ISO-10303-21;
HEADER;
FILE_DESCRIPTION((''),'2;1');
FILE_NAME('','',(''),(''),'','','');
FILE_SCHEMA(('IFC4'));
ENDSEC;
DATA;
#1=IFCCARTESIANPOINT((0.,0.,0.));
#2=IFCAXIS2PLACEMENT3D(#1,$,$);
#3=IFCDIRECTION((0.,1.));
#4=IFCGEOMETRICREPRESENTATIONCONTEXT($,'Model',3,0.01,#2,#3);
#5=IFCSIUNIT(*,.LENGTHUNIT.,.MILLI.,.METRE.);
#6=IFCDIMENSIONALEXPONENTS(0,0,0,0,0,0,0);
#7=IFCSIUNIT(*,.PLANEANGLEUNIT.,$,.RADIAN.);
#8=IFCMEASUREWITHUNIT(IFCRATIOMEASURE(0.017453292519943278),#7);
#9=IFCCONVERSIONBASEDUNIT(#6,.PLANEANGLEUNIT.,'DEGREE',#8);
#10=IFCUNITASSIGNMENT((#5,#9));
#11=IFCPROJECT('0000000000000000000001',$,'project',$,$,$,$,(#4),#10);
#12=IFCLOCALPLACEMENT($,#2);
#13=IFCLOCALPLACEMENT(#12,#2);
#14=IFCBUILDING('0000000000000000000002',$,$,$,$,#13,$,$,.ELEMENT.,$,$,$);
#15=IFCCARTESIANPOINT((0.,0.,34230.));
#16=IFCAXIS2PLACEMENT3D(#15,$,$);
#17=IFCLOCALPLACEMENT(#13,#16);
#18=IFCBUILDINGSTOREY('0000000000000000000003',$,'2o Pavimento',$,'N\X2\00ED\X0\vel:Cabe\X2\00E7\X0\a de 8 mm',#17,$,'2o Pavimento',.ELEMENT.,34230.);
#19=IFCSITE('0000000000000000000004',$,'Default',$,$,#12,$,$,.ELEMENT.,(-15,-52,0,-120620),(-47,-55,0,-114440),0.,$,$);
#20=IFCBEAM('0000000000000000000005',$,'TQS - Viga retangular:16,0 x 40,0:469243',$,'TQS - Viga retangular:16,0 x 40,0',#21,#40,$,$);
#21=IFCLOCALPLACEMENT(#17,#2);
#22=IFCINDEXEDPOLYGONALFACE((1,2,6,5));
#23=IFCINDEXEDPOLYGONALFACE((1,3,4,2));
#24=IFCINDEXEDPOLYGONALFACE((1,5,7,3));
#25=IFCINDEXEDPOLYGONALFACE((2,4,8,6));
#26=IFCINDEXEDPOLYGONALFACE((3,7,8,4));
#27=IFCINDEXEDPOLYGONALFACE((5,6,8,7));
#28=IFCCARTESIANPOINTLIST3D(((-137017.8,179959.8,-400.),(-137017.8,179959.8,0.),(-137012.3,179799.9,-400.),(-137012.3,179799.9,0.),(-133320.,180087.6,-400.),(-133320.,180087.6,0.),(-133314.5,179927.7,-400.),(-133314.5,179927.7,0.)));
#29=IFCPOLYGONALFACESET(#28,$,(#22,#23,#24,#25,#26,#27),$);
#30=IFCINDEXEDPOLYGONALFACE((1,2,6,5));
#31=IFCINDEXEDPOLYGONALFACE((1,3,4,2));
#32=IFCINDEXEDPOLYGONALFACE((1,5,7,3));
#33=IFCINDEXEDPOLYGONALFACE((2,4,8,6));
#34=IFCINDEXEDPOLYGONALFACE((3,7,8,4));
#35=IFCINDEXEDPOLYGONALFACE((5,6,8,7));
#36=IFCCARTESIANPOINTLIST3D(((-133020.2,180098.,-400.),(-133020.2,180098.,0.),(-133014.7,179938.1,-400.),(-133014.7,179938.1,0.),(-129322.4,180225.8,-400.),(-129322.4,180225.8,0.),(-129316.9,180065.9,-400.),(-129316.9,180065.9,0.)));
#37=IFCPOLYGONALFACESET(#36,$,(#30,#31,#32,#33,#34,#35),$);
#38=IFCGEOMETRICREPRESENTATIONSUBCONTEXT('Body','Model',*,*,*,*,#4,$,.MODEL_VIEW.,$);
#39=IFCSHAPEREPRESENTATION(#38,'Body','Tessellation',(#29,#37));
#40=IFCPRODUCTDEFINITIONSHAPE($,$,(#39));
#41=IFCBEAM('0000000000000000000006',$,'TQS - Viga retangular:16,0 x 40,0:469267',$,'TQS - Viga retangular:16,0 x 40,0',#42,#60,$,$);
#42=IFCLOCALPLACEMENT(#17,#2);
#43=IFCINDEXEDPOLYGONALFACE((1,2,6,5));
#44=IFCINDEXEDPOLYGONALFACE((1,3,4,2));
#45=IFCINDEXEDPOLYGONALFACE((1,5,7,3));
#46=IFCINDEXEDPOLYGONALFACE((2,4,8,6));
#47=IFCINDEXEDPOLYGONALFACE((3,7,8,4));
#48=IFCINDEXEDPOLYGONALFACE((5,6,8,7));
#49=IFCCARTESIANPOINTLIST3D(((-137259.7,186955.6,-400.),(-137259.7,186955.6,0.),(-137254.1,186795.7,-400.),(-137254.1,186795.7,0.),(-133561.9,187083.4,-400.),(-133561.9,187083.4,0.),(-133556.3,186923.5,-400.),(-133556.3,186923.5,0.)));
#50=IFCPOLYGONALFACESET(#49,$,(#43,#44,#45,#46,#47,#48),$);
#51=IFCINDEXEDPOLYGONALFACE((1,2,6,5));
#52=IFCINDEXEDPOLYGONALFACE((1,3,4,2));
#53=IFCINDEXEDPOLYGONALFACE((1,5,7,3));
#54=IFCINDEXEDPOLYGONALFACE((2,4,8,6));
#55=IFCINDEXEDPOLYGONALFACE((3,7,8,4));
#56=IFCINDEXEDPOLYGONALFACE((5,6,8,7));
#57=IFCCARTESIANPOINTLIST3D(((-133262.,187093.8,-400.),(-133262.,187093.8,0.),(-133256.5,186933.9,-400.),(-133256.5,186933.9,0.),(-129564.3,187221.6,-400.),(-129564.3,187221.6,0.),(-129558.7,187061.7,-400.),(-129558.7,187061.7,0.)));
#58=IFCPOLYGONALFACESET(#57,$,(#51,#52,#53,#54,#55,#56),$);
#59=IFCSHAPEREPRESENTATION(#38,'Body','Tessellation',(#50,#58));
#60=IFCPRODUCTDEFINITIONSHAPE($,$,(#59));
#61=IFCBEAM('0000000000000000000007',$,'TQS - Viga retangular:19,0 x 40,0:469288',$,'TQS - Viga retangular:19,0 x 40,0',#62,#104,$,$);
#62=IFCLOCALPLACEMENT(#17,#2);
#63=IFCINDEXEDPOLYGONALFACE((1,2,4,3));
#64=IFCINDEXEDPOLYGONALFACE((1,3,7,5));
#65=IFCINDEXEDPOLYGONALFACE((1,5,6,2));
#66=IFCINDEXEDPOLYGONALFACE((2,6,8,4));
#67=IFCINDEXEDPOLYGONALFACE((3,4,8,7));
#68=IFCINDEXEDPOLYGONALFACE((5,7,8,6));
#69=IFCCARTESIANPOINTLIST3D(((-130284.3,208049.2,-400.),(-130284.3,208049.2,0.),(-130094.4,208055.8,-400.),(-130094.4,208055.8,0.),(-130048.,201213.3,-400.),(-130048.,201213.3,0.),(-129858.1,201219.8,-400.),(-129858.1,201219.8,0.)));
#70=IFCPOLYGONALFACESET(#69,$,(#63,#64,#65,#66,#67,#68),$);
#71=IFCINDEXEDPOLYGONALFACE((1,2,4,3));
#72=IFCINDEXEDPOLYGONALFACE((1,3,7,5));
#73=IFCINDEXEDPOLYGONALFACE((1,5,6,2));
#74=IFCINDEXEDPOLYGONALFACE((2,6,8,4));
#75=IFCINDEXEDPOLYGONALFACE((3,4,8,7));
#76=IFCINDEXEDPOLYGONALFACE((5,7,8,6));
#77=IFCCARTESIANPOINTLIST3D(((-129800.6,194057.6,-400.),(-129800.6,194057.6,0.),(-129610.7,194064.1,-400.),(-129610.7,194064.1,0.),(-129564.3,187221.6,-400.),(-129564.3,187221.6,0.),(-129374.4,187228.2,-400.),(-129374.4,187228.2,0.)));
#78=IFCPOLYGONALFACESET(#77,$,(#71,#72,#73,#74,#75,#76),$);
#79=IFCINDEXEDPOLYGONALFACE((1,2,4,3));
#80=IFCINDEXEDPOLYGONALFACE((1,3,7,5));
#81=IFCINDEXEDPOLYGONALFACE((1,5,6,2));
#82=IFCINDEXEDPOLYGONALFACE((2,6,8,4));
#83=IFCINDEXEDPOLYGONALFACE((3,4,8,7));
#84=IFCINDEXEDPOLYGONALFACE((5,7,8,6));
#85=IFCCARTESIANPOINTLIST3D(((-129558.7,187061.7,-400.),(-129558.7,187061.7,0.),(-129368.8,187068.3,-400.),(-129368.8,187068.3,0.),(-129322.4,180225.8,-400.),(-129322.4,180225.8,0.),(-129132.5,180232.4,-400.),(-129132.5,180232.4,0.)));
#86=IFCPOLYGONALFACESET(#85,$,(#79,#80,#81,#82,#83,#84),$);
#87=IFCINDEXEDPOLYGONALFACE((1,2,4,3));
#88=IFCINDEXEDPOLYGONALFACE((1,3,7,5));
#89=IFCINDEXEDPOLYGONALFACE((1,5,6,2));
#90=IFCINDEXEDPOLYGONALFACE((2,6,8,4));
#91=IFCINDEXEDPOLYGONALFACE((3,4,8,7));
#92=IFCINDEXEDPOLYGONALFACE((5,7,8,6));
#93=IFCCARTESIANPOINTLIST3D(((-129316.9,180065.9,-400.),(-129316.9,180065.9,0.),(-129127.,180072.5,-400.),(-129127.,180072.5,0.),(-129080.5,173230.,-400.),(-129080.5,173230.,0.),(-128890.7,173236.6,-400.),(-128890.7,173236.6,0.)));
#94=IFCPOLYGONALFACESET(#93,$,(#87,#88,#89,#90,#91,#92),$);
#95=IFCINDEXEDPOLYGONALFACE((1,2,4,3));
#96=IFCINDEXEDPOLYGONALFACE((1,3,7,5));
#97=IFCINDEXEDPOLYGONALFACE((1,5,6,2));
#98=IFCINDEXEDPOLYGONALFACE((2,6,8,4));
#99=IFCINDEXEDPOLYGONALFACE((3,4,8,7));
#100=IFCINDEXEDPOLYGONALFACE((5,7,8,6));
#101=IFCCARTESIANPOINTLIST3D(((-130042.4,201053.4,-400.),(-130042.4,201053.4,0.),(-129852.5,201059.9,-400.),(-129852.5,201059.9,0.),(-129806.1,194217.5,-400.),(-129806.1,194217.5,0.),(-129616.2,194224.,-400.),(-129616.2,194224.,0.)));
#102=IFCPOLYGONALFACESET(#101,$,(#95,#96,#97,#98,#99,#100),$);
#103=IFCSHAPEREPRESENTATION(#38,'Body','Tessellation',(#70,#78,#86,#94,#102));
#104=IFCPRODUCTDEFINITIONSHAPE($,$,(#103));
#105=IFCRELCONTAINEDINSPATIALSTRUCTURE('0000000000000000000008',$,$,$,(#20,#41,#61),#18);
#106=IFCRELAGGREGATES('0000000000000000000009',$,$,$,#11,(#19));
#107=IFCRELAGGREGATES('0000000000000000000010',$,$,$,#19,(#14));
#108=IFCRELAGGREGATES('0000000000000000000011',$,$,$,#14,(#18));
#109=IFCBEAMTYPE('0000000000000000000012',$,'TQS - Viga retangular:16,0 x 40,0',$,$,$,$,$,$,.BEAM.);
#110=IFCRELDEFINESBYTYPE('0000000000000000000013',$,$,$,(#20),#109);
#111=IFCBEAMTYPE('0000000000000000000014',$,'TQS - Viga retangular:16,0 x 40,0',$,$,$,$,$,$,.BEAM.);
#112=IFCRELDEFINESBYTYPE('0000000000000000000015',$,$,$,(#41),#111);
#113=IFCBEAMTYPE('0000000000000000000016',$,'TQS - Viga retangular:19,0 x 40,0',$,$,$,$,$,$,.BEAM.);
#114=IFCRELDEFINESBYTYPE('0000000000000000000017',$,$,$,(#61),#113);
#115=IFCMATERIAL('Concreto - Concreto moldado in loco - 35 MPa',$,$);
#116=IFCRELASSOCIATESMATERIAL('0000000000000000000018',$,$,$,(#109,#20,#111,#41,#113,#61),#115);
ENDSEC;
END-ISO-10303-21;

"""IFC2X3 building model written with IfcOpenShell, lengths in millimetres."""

from ifc_helpers import new_model, entity, si_unit, converted_unit, direction, frame, frame_2d, origin, place, context, subcontext, project, spatial, rectangle, extrude, source, transform, mapped, material, type_object, type_shapes, element, save


model = new_model("IFC2X3")

# Units and contexts
model_context = context("Model", 3, precision=0.01, world=origin(), true_north=direction((0.0, 1.0)))
body_context = subcontext(model_context, "Body", "Model", "MODEL_VIEW")
ifc_project = project(units=[si_unit("LENGTHUNIT", "METRE", prefix="MILLI"), converted_unit("PLANEANGLEUNIT", "DEGREE", entity("IfcRatioMeasure", 0.017453292519943278), si_unit("PLANEANGLEUNIT", "RADIAN"), dimensions=[0, 0, 0, 0, 0, 0, 0])], contexts=[model_context])

# Site, building, storey
site_placement = place(None, origin())
site = spatial("IfcSite", under=ifc_project, at=site_placement, Name="Default", CompositionType="ELEMENT", RefLatitude=(-15, -52, 0, -120620), RefLongitude=(-47, -55, 0, -114440), RefElevation=0.0)
building_placement = place(site_placement, origin())
building = spatial("IfcBuilding", under=site, at=building_placement, CompositionType="ELEMENT")
storey_placement = place(building_placement, frame((0.0, 0.0, 34230.0)))
storey = spatial("IfcBuildingStorey", under=building, at=storey_placement, Name="2o Pavimento", ObjectType="Nível:Cabeça de 8 mm", LongName="2o Pavimento", CompositionType="ELEMENT", Elevation=34230.0)

# Shared definitions
ifc_material = material(Name="Concreto - Concreto moldado in loco - 35 MPa")

# Beams
beam_type_1 = type_object("IfcBeamType", Name="TQS - Viga retangular:16,0 x 40,0", PredefinedType="BEAM", material=ifc_material)
shared_shape_1 = source(origin(), body_context, "Body", "SweptSolid", [
    extrude(rectangle(XDim=400.0, YDim=160.0, at=frame_2d((0.0, 0.0), x_axis=(1.0, 0.0))), frame((-133317.2, 180007.7, 34030.0), z_axis=(-0.999403, -0.034551, 0.0), x_axis=(0.0, 0.0, -1.0)), (0.0, 0.0, 1.0), 3700.0),
    extrude(rectangle(XDim=400.0, YDim=160.0, at=frame_2d((0.0, 0.0), x_axis=(1.0, 0.0))), frame((-129319.6, 180145.9, 34030.0), z_axis=(-0.999403, -0.034551, 0.0), x_axis=(0.0, 0.0, -1.0)), (0.0, 0.0, 1.0), 3700.0),
])
type_shapes(beam_type_1, [shared_shape_1])
beam_1_placement = place(storey_placement, frame((0.0, 0.0, -34230.0)))
element("IfcBeam", 1, at=beam_1_placement, inside=storey, type_object=beam_type_1, material=ifc_material, Name="TQS - Viga retangular:16,0 x 40,0:469243", ObjectType="TQS - Viga retangular:16,0 x 40,0", context=body_context, shape_type="MappedRepresentation", body=[
    mapped(shared_shape_1, transform((0.0, 0.0, 0.0), scale=1.0)),
])
beam_type_2 = type_object("IfcBeamType", Name="TQS - Viga retangular:16,0 x 40,0", PredefinedType="BEAM", material=ifc_material)
shared_shape_2 = source(origin(), body_context, "Body", "SweptSolid", [
    extrude(rectangle(XDim=400.0, YDim=160.0, at=frame_2d((0.0, 0.0), x_axis=(1.0, 0.0))), frame((-133559.1, 187003.5, 34030.0), z_axis=(-0.999403, -0.034551, 0.0), x_axis=(0.0, 0.0, -1.0)), (0.0, 0.0, 1.0), 3700.0),
    extrude(rectangle(XDim=400.0, YDim=160.0, at=frame_2d((0.0, 0.0), x_axis=(1.0, 0.0))), frame((-129561.5, 187141.7, 34030.0), z_axis=(-0.999403, -0.034551, 0.0), x_axis=(0.0, 0.0, -1.0)), (0.0, 0.0, 1.0), 3700.0),
])
type_shapes(beam_type_2, [shared_shape_2])
beam_2_placement = place(storey_placement, frame((0.0, 0.0, -34230.0)))
element("IfcBeam", 2, at=beam_2_placement, inside=storey, type_object=beam_type_2, material=ifc_material, Name="TQS - Viga retangular:16,0 x 40,0:469267", ObjectType="TQS - Viga retangular:16,0 x 40,0", context=body_context, shape_type="MappedRepresentation", body=[
    mapped(shared_shape_2, transform((0.0, 0.0, 0.0), scale=1.0)),
])
beam_type_3 = type_object("IfcBeamType", Name="TQS - Viga retangular:19,0 x 40,0", PredefinedType="BEAM", material=ifc_material)
shared_shape_3 = source(origin(), body_context, "Body", "SweptSolid", [
    extrude(rectangle(XDim=400.0, YDim=190.0, at=frame_2d((0.0, 0.0), x_axis=(1.0, 0.0))), frame((-129953.0, 201216.6, 34030.0), z_axis=(-0.034551, 0.999403, 0.0), x_axis=(0.0, 0.0, 1.0)), (0.0, 0.0, 1.0), 6840.0),
    extrude(rectangle(XDim=400.0, YDim=190.0, at=frame_2d((0.0, 0.0), x_axis=(1.0, 0.0))), frame((-129469.3, 187224.9, 34030.0), z_axis=(-0.034551, 0.999403, 0.0), x_axis=(0.0, 0.0, 1.0)), (0.0, 0.0, 1.0), 6840.0),
    extrude(rectangle(XDim=400.0, YDim=190.0, at=frame_2d((0.0, 0.0), x_axis=(1.0, 0.0))), frame((-129227.5, 180229.1, 34030.0), z_axis=(-0.034551, 0.999403, 0.0), x_axis=(0.0, 0.0, 1.0)), (0.0, 0.0, 1.0), 6840.0),
    extrude(rectangle(XDim=400.0, YDim=190.0, at=frame_2d((0.0, 0.0), x_axis=(1.0, 0.0))), frame((-128985.6, 173233.3, 34030.0), z_axis=(-0.034551, 0.999403, 0.0), x_axis=(0.0, 0.0, 1.0)), (0.0, 0.0, 1.0), 6840.0),
    extrude(rectangle(XDim=400.0, YDim=190.0, at=frame_2d((0.0, 0.0), x_axis=(1.0, 0.0))), frame((-129711.2, 194220.7, 34030.0), z_axis=(-0.034551, 0.999403, 0.0), x_axis=(0.0, 0.0, 1.0)), (0.0, 0.0, 1.0), 6840.0),
])
type_shapes(beam_type_3, [shared_shape_3])
beam_3_placement = place(storey_placement, frame((0.0, 0.0, -34230.0)))
element("IfcBeam", 3, at=beam_3_placement, inside=storey, type_object=beam_type_3, material=ifc_material, Name="TQS - Viga retangular:19,0 x 40,0:469288", ObjectType="TQS - Viga retangular:19,0 x 40,0", context=body_context, shape_type="MappedRepresentation", body=[
    mapped(shared_shape_3, transform((0.0, 0.0, 0.0), scale=1.0)),
])

save(model, "model.ifc")
